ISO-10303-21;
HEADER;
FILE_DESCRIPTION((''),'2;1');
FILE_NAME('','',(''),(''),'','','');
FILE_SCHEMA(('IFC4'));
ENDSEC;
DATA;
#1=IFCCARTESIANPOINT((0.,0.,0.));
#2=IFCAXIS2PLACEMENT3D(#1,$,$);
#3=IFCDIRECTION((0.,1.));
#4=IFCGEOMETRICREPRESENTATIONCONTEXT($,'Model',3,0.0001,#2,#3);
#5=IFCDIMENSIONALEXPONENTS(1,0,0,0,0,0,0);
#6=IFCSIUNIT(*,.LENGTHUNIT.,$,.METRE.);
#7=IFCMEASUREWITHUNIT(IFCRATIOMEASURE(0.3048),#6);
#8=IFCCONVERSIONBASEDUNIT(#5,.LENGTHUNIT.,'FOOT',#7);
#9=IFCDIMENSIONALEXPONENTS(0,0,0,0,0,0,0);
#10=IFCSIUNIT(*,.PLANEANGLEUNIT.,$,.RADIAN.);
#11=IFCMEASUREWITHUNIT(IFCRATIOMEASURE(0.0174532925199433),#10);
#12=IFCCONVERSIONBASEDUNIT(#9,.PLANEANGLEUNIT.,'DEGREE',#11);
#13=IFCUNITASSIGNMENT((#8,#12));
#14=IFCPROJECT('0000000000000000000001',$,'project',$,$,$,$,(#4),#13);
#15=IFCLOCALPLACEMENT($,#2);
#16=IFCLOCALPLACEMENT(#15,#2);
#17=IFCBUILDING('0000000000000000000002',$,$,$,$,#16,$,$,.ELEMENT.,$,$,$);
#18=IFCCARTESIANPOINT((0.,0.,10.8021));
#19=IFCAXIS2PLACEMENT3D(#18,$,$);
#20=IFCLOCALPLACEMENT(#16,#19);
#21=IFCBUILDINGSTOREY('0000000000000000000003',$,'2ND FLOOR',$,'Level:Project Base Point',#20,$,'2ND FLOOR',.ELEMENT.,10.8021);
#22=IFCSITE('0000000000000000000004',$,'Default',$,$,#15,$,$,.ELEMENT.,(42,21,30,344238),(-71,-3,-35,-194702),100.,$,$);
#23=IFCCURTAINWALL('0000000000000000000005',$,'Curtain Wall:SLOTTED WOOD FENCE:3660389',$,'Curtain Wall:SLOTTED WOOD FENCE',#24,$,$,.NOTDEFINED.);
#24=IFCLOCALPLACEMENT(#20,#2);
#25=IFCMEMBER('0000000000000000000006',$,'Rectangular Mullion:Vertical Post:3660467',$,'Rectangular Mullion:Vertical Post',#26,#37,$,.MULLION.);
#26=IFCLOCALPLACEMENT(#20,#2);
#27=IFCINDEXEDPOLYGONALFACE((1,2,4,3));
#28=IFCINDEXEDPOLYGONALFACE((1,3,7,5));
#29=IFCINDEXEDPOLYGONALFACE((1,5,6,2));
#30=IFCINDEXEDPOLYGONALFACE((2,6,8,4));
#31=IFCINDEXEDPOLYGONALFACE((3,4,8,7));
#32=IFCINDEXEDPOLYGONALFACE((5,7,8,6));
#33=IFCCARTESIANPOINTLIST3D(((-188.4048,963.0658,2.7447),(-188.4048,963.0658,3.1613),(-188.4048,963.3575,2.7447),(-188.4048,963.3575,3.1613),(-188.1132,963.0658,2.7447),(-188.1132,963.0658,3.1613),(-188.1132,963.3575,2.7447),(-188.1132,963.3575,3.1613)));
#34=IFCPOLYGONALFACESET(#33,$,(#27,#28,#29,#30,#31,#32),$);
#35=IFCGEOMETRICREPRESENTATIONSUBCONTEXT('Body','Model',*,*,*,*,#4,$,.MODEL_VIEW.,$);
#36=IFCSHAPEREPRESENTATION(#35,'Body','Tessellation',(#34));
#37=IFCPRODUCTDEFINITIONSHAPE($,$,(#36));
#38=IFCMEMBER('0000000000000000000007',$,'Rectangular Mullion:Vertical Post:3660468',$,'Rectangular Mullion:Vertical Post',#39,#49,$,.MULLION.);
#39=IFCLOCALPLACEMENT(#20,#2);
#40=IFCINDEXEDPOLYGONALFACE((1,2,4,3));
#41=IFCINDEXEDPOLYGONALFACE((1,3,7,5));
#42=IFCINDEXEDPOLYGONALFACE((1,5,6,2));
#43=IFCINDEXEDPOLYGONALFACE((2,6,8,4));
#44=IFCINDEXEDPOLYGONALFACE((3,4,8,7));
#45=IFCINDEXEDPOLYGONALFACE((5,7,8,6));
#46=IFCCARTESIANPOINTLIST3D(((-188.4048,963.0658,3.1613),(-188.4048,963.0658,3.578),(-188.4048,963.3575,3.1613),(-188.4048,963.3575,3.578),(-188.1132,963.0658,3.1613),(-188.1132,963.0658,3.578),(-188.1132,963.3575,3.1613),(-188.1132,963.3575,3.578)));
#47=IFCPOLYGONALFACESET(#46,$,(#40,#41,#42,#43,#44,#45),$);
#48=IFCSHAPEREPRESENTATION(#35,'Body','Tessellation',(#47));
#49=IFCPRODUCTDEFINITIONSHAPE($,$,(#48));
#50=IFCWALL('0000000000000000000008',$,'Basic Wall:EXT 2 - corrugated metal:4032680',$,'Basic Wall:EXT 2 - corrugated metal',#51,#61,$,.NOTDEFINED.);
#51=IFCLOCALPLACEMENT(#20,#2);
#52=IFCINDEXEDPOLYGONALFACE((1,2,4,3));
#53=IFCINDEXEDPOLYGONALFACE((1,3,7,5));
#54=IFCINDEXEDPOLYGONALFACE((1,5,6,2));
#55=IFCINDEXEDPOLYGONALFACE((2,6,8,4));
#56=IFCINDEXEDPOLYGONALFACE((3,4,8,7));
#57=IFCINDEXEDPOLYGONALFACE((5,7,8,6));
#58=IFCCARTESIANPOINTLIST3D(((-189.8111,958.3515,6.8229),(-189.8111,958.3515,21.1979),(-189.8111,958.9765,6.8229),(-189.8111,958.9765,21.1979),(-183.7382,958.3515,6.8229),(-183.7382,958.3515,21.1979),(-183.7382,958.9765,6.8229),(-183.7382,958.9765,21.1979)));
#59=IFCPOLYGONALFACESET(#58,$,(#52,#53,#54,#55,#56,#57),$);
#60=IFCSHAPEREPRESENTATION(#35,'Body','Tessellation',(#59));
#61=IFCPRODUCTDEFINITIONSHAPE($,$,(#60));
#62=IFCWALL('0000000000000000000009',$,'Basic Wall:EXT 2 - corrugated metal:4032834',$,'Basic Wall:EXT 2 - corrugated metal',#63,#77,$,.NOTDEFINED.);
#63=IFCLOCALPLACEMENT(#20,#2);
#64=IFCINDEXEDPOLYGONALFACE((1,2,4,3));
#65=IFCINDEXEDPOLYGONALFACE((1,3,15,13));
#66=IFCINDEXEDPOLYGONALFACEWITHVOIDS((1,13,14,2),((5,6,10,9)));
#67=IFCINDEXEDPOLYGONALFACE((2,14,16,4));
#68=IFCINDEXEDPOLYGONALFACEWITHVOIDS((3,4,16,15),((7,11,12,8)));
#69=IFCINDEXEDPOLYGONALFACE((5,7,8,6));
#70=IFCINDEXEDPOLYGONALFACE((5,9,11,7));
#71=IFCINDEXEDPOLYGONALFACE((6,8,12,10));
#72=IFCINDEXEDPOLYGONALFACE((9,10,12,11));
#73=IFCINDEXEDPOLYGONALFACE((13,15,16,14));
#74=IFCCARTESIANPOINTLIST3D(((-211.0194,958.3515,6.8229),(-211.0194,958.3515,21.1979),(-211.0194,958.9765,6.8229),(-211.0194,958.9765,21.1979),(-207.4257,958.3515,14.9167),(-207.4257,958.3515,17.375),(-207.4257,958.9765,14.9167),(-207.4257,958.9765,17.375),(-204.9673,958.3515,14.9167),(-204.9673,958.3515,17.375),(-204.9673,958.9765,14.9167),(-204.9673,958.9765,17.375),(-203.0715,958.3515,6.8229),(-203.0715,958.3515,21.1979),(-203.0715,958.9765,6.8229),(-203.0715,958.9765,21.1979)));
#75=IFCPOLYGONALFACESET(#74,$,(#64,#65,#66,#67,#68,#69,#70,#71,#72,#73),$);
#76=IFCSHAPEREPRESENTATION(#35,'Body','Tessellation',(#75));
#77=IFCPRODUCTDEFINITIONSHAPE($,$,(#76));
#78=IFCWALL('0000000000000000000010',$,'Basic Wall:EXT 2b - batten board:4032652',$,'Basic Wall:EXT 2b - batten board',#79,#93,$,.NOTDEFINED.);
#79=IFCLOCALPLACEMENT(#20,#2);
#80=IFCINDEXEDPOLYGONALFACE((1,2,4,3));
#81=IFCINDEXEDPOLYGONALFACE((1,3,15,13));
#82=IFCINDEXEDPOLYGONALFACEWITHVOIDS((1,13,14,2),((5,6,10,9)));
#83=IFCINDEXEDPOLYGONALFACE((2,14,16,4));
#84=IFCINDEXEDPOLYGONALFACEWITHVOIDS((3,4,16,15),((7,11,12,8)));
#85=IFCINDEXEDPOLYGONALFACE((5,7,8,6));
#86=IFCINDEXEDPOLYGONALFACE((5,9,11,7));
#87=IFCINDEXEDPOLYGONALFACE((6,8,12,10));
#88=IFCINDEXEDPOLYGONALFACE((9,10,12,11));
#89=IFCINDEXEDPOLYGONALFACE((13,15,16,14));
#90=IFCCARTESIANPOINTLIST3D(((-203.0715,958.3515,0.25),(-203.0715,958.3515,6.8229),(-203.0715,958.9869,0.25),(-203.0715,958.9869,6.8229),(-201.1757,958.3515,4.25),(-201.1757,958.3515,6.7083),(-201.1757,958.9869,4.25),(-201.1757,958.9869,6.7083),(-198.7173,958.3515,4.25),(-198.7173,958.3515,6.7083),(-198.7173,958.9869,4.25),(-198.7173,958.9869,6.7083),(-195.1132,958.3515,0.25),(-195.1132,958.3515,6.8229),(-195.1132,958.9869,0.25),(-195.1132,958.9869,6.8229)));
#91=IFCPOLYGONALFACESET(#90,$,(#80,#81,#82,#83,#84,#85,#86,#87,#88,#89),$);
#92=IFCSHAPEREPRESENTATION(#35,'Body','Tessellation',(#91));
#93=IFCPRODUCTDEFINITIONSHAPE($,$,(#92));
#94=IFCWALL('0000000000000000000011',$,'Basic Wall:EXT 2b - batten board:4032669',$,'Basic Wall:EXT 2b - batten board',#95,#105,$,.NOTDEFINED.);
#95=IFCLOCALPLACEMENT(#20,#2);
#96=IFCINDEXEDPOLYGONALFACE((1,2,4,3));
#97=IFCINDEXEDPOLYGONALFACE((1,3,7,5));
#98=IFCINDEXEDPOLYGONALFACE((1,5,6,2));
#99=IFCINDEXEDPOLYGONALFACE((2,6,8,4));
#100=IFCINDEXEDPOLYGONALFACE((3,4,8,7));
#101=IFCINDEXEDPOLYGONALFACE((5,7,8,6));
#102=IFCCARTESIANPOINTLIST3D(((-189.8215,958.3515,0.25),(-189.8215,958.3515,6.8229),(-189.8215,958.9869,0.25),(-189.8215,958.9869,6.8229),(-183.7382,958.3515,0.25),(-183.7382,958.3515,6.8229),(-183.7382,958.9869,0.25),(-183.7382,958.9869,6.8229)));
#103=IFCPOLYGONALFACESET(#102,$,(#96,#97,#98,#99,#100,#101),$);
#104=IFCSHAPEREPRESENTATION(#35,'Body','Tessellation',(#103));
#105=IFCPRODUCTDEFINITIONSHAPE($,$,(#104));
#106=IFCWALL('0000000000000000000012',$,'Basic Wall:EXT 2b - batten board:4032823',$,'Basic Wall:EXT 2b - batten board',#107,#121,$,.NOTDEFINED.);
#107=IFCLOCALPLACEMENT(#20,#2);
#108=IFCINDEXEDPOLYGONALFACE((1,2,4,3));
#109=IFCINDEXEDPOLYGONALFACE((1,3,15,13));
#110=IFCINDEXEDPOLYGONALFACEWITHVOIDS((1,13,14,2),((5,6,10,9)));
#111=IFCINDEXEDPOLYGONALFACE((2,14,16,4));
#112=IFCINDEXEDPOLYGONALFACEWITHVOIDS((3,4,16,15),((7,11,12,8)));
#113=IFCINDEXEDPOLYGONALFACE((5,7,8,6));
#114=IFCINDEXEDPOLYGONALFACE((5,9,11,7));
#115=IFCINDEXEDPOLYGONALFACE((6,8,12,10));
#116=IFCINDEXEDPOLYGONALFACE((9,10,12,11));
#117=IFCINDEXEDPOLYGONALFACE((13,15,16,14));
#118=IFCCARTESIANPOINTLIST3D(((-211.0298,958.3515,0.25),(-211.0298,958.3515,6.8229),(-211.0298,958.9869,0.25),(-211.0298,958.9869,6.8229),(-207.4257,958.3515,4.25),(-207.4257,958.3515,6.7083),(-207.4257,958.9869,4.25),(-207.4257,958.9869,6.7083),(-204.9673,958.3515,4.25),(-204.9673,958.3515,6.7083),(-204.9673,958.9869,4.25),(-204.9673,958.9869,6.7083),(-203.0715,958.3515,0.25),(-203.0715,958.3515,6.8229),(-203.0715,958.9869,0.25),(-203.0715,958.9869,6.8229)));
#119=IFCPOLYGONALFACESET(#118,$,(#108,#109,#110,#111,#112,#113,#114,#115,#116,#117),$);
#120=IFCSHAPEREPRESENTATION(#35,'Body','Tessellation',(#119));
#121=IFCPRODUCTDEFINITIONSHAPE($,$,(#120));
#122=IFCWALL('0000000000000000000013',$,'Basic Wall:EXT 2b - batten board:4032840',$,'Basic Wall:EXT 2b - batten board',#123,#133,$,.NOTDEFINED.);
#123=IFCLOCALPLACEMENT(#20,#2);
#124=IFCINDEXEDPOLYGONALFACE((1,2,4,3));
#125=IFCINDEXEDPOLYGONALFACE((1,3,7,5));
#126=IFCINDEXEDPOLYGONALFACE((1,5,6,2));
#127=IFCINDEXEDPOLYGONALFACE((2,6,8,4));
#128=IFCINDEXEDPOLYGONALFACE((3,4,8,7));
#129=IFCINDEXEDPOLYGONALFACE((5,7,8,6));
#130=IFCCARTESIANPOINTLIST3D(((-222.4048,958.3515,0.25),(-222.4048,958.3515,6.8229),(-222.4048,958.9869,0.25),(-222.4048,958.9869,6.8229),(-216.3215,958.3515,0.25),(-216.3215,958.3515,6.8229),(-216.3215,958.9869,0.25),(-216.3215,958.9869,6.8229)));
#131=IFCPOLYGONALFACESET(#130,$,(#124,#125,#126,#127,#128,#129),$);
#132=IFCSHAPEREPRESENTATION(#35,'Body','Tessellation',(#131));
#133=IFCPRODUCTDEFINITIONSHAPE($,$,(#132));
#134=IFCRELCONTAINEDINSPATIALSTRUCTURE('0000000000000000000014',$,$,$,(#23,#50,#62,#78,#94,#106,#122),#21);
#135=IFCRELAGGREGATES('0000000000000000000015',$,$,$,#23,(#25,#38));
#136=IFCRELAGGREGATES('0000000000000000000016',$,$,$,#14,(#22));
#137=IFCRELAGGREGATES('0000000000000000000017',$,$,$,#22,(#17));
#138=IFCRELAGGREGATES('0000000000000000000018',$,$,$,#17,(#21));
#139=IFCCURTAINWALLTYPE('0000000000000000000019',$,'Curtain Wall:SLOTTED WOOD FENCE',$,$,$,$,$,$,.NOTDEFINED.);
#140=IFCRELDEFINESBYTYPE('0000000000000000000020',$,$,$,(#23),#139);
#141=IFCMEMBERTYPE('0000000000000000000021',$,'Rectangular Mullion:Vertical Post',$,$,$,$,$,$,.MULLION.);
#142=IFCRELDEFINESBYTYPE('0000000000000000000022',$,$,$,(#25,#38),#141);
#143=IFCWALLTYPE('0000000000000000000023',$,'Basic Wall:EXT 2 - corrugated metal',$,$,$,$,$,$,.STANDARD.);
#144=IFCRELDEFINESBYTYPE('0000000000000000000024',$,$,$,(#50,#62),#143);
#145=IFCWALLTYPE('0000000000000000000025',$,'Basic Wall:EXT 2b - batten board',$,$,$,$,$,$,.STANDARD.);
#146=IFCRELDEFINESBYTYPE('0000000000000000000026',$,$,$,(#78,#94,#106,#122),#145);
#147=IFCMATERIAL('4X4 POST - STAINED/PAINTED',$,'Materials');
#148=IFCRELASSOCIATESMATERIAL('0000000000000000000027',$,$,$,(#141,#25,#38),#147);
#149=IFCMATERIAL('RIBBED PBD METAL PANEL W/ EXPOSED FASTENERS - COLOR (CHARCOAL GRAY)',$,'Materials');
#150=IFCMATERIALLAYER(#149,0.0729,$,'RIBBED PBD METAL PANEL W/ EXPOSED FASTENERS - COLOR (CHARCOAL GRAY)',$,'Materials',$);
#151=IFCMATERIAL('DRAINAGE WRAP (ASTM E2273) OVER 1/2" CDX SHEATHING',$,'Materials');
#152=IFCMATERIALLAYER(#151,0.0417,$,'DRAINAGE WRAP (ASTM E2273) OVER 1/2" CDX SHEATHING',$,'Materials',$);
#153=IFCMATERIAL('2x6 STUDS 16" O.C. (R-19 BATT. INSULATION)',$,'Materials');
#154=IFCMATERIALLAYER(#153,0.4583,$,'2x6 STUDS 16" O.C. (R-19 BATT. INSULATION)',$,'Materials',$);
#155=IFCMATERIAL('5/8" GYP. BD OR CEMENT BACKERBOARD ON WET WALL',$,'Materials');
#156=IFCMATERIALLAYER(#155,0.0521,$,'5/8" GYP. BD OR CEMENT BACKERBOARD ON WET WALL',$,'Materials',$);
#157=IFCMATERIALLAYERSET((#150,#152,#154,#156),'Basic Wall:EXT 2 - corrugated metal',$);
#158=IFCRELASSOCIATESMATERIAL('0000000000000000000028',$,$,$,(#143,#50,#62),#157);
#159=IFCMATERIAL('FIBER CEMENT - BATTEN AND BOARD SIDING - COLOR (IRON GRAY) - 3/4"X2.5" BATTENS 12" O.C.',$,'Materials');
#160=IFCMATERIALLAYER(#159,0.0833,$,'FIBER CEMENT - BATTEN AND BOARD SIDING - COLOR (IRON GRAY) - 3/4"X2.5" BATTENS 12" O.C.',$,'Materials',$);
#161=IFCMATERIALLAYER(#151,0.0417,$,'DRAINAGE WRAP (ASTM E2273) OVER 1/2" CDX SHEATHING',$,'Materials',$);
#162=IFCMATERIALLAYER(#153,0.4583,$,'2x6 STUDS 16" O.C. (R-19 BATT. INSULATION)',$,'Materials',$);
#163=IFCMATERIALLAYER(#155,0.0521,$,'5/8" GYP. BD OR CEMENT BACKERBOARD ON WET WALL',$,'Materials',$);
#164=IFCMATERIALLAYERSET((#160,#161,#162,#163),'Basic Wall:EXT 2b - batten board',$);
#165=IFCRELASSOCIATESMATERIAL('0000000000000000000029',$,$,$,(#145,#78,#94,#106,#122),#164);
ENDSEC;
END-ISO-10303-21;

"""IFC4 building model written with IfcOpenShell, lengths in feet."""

from ifc_helpers import new_model, entity, si_unit, converted_unit, direction, frame, frame_2d, origin, origin_2d_with_axis, place, context, subcontext, project, spatial, rectangle, extrude, source, transform, mapped, material, layer, layer_set, layer_usage, material_profile, profile_set, profile_usage, type_object, type_shapes, element, aggregate, save


model = new_model("IFC4")

# Units and contexts
model_context = context("Model", 3, precision=0.0001, world=origin(), true_north=direction((0.0, 1.0)))
body_context = subcontext(model_context, "Body", "Model", "MODEL_VIEW")
ifc_project = project(units=[converted_unit("LENGTHUNIT", "FOOT", entity("IfcRatioMeasure", 0.3048), si_unit("LENGTHUNIT", "METRE"), dimensions=[1, 0, 0, 0, 0, 0, 0]), converted_unit("PLANEANGLEUNIT", "DEGREE", entity("IfcRatioMeasure", 0.0174532925199433), si_unit("PLANEANGLEUNIT", "RADIAN"), dimensions=[0, 0, 0, 0, 0, 0, 0])], contexts=[model_context])

# Site, building, storey
site_placement = place(None, origin())
site = spatial("IfcSite", under=ifc_project, at=site_placement, Name="Default", CompositionType="ELEMENT", RefLatitude=(42, 21, 30, 344238), RefLongitude=(-71, -3, -35, -194702), RefElevation=100.0)
building_placement = place(site_placement, origin())
building = spatial("IfcBuilding", under=site, at=building_placement, CompositionType="ELEMENT")
storey_placement = place(building_placement, frame((0.0, 0.0, 10.8021)))
storey = spatial("IfcBuildingStorey", under=building, at=storey_placement, Name="2ND FLOOR", ObjectType="Level:Project Base Point", LongName="2ND FLOOR", CompositionType="ELEMENT", Elevation=10.8021)

# Curtain wall, members
curtain_wall_type = type_object("IfcCurtainWallType", Name="Curtain Wall:SLOTTED WOOD FENCE", PredefinedType="NOTDEFINED")
ifc_material_1 = material(Name="4X4 POST - STAINED/PAINTED", Category="Materials")
ifc_material_profile = material_profile(ifc_material_1, rectangle(XDim=0.2917, YDim=0.2917, at=origin_2d_with_axis()), Name="Vertical Post")
ifc_profile_set = profile_set([ifc_material_profile], Name="Vertical Post")
curtain_wall_1_placement = place(storey_placement, frame((0.0, 0.0, -10.8021)))
curtain_wall_1 = element("IfcCurtainWall", 1, at=curtain_wall_1_placement, inside=storey, type_object=curtain_wall_type, Name="Curtain Wall:SLOTTED WOOD FENCE:3660389", ObjectType="Curtain Wall:SLOTTED WOOD FENCE", PredefinedType="NOTDEFINED")
member_type_1 = type_object("IfcMemberType", Name="Rectangular Mullion:Vertical Post", PredefinedType="MULLION", material=ifc_profile_set)
shared_shape_1 = source(origin(), body_context, "Body", "SweptSolid", [
    extrude(rectangle(XDim=0.2917, YDim=0.2917, at=origin_2d_with_axis()), frame((-0.1458, 0.2083, -0.4167), z_axis=(0.0, 0.0, 1.0), x_axis=(0.0, -1.0, 0.0)), (0.0, 0.0, 1.0), 0.4167),
])
type_shapes(member_type_1, [shared_shape_1])
ifc_profile_usage_1 = profile_usage(ifc_profile_set)
member_1_placement = place(storey_placement, frame((-188.0507, 963.0658, 2.7447), z_axis=(0.0, 0.0, -1.0), x_axis=(0.0, -1.0, 0.0)))
member_1 = element("IfcMember", 2, at=member_1_placement, type_object=member_type_1, material=ifc_profile_usage_1, Name="Rectangular Mullion:Vertical Post:3660467", ObjectType="Rectangular Mullion:Vertical Post", PredefinedType="MULLION", context=body_context, shape_type="MappedRepresentation", body=[
    mapped(shared_shape_1, transform((0.0, 0.0, 0.0), scale=1.0)),
])
ifc_profile_usage_2 = profile_usage(ifc_profile_set)
member_2_placement = place(storey_placement, frame((-188.0507, 963.0658, 3.1613), z_axis=(0.0, 0.0, -1.0), x_axis=(0.0, -1.0, 0.0)))
member_2 = element("IfcMember", 3, at=member_2_placement, type_object=member_type_1, material=ifc_profile_usage_2, Name="Rectangular Mullion:Vertical Post:3660468", ObjectType="Rectangular Mullion:Vertical Post", PredefinedType="MULLION", context=body_context, shape_type="MappedRepresentation", body=[
    mapped(shared_shape_1, transform((0.0, 0.0, 0.0), scale=1.0)),
])
aggregate(curtain_wall_1, [member_1, member_2])

# Wall
ifc_material_2 = material(Name="RIBBED PBD METAL PANEL W/ EXPOSED FASTENERS - COLOR (CHARCOAL GRAY)", Category="Materials")
ifc_layer_1 = layer(ifc_material_2, 0.0729, Name="RIBBED PBD METAL PANEL W/ EXPOSED FASTENERS - COLOR (CHARCOAL GRAY)", Category="Materials")
ifc_material_3 = material(Name="DRAINAGE WRAP (ASTM E2273) OVER 1/2\" CDX SHEATHING", Category="Materials")
ifc_layer_2 = layer(ifc_material_3, 0.0417, Name="DRAINAGE WRAP (ASTM E2273) OVER 1/2\" CDX SHEATHING", Category="Materials")
ifc_material_4 = material(Name="2x6 STUDS 16\" O.C. (R-19 BATT. INSULATION)", Category="Materials")
ifc_layer_3 = layer(ifc_material_4, 0.4583, Name="2x6 STUDS 16\" O.C. (R-19 BATT. INSULATION)", Category="Materials")
ifc_material_5 = material(Name="5/8\" GYP. BD OR CEMENT BACKERBOARD ON WET WALL", Category="Materials")
ifc_layer_4 = layer(ifc_material_5, 0.0521, Name="5/8\" GYP. BD OR CEMENT BACKERBOARD ON WET WALL", Category="Materials")
ifc_layer_set_1 = layer_set([ifc_layer_1, ifc_layer_2, ifc_layer_3, ifc_layer_4], Name="Basic Wall:EXT 2 - corrugated metal")
ifc_layer_usage_1 = layer_usage(ifc_layer_set_1, "AXIS2", "NEGATIVE", 0.3125)
wall_type_1 = type_object("IfcWallType", Name="Basic Wall:EXT 2 - corrugated metal", PredefinedType="STANDARD", material=ifc_layer_set_1)
wall_1_placement = place(storey_placement, frame((-189.8111, 958.664, 6.8229)))
element("IfcWall", 4, at=wall_1_placement, inside=storey, type_object=wall_type_1, material=ifc_layer_usage_1, Name="Basic Wall:EXT 2 - corrugated metal:4032680", ObjectType="Basic Wall:EXT 2 - corrugated metal", PredefinedType="NOTDEFINED", context=body_context, shape_type="SweptSolid", body=[
    extrude(rectangle(XDim=6.0729, YDim=0.625, at=frame_2d((3.0365, 0.0), x_axis=(-1.0, 0.0))), origin(), (0.0, 0.0, 1.0), 14.375),
])

# Walls, openings
ifc_layer_usage_2 = layer_usage(ifc_layer_set_1, "AXIS2", "POSITIVE", -0.3125)
wall_2_placement = place(storey_placement, frame((-203.0715, 958.664, 6.8229), z_axis=(0.0, 0.0, 1.0), x_axis=(-1.0, 0.0, 0.0)))
wall_2 = element("IfcWall", 5, at=wall_2_placement, inside=storey, type_object=wall_type_1, material=ifc_layer_usage_2, Name="Basic Wall:EXT 2 - corrugated metal:4032834", ObjectType="Basic Wall:EXT 2 - corrugated metal", PredefinedType="NOTDEFINED", context=body_context, shape_type="SweptSolid", body=[
    extrude(rectangle(XDim=7.9479, YDim=0.625, at=frame_2d((3.974, 0.0), x_axis=(-1.0, 0.0))), origin(), (0.0, 0.0, 1.0), 14.375),
])
opening_1_placement = place(wall_2_placement, frame((4.3542, 0.3125, 8.0938)))
element("IfcOpeningElement", 6, at=opening_1_placement, cuts=wall_2, PredefinedType="OPENING", context=body_context, shape_type="SweptSolid", body=[
    extrude(rectangle(XDim=2.4583, YDim=2.4583, at=frame_2d((0.0, 0.0), x_axis=(1.0, 0.0))), frame((-1.2292, -1.625, 1.2292), z_axis=(0.0, 1.0, 0.0), x_axis=(0.0, 0.0, -1.0)), (0.0, 0.0, 1.0), 1.625),
])
ifc_material_6 = material(Name="FIBER CEMENT - BATTEN AND BOARD SIDING - COLOR (IRON GRAY) - 3/4\"X2.5\" BATTENS 12\" O.C.", Category="Materials")
ifc_layer_5 = layer(ifc_material_6, 0.0833, Name="FIBER CEMENT - BATTEN AND BOARD SIDING - COLOR (IRON GRAY) - 3/4\"X2.5\" BATTENS 12\" O.C.", Category="Materials")
ifc_layer_6 = layer(ifc_material_3, 0.0417, Name="DRAINAGE WRAP (ASTM E2273) OVER 1/2\" CDX SHEATHING", Category="Materials")
ifc_layer_7 = layer(ifc_material_4, 0.4583, Name="2x6 STUDS 16\" O.C. (R-19 BATT. INSULATION)", Category="Materials")
ifc_layer_8 = layer(ifc_material_5, 0.0521, Name="5/8\" GYP. BD OR CEMENT BACKERBOARD ON WET WALL", Category="Materials")
ifc_layer_set_2 = layer_set([ifc_layer_5, ifc_layer_6, ifc_layer_7, ifc_layer_8], Name="Basic Wall:EXT 2b - batten board")
ifc_layer_usage_3 = layer_usage(ifc_layer_set_2, "AXIS2", "NEGATIVE", 0.3177)
wall_type_2 = type_object("IfcWallType", Name="Basic Wall:EXT 2b - batten board", PredefinedType="STANDARD", material=ifc_layer_set_2)
wall_3_placement = place(storey_placement, frame((-203.0715, 958.6692, 0.25)))
wall_3 = element("IfcWall", 7, at=wall_3_placement, inside=storey, type_object=wall_type_2, material=ifc_layer_usage_3, Name="Basic Wall:EXT 2b - batten board:4032652", ObjectType="Basic Wall:EXT 2b - batten board", PredefinedType="NOTDEFINED", context=body_context, shape_type="SweptSolid", body=[
    extrude(rectangle(XDim=7.9583, YDim=0.6354, at=frame_2d((3.9792, 0.0), x_axis=(-1.0, 0.0))), origin(), (0.0, 0.0, 1.0), 6.5729),
])
opening_2_placement = place(wall_3_placement, frame((1.8958, -0.3177, 4.0)))
element("IfcOpeningElement", 8, at=opening_2_placement, cuts=wall_3, PredefinedType="OPENING", context=body_context, shape_type="SweptSolid", body=[
    extrude(rectangle(XDim=2.4583, YDim=2.4583, at=frame_2d((0.0, 0.0), x_axis=(1.0, 0.0))), frame((1.2292, 0.0, 1.2292), z_axis=(0.0, 1.0, 0.0), x_axis=(0.0, 0.0, -1.0)), (0.0, 0.0, 1.0), 1.6354),
])

# Wall
ifc_layer_usage_4 = layer_usage(ifc_layer_set_2, "AXIS2", "NEGATIVE", 0.3177)
wall_4_placement = place(storey_placement, frame((-189.8215, 958.6692, 0.25)))
element("IfcWall", 9, at=wall_4_placement, inside=storey, type_object=wall_type_2, material=ifc_layer_usage_4, Name="Basic Wall:EXT 2b - batten board:4032669", ObjectType="Basic Wall:EXT 2b - batten board", PredefinedType="NOTDEFINED", context=body_context, shape_type="SweptSolid", body=[
    extrude(rectangle(XDim=6.0833, YDim=0.6354, at=frame_2d((3.0417, 0.0), x_axis=(-1.0, 0.0))), origin(), (0.0, 0.0, 1.0), 6.5729),
])

# Wall, opening
ifc_layer_usage_5 = layer_usage(ifc_layer_set_2, "AXIS2", "POSITIVE", -0.3177)
wall_5_placement = place(storey_placement, frame((-203.0715, 958.6692, 0.25), z_axis=(0.0, 0.0, 1.0), x_axis=(-1.0, 0.0, 0.0)))
wall_5 = element("IfcWall", 10, at=wall_5_placement, inside=storey, type_object=wall_type_2, material=ifc_layer_usage_5, Name="Basic Wall:EXT 2b - batten board:4032823", ObjectType="Basic Wall:EXT 2b - batten board", PredefinedType="NOTDEFINED", context=body_context, shape_type="SweptSolid", body=[
    extrude(rectangle(XDim=7.9583, YDim=0.6354, at=frame_2d((3.9792, 0.0), x_axis=(-1.0, 0.0))), origin(), (0.0, 0.0, 1.0), 6.5729),
])
opening_3_placement = place(wall_5_placement, frame((4.3542, 0.3177, 4.0)))
element("IfcOpeningElement", 11, at=opening_3_placement, cuts=wall_5, PredefinedType="OPENING", context=body_context, shape_type="SweptSolid", body=[
    extrude(rectangle(XDim=2.4583, YDim=2.4583, at=frame_2d((0.0, 0.0), x_axis=(1.0, 0.0))), frame((-1.2292, -1.6354, 1.2292), z_axis=(0.0, 1.0, 0.0), x_axis=(0.0, 0.0, -1.0)), (0.0, 0.0, 1.0), 1.6354),
])

# Wall
ifc_layer_usage_6 = layer_usage(ifc_layer_set_2, "AXIS2", "POSITIVE", -0.3177)
wall_6_placement = place(storey_placement, frame((-216.3215, 958.6692, 0.25), z_axis=(0.0, 0.0, 1.0), x_axis=(-1.0, 0.0, 0.0)))
element("IfcWall", 12, at=wall_6_placement, inside=storey, type_object=wall_type_2, material=ifc_layer_usage_6, Name="Basic Wall:EXT 2b - batten board:4032840", ObjectType="Basic Wall:EXT 2b - batten board", PredefinedType="NOTDEFINED", context=body_context, shape_type="SweptSolid", body=[
    extrude(rectangle(XDim=6.0833, YDim=0.6354, at=frame_2d((3.0417, 0.0), x_axis=(-1.0, 0.0))), origin(), (0.0, 0.0, 1.0), 6.5729),
])

save(model, "model.ifc")
